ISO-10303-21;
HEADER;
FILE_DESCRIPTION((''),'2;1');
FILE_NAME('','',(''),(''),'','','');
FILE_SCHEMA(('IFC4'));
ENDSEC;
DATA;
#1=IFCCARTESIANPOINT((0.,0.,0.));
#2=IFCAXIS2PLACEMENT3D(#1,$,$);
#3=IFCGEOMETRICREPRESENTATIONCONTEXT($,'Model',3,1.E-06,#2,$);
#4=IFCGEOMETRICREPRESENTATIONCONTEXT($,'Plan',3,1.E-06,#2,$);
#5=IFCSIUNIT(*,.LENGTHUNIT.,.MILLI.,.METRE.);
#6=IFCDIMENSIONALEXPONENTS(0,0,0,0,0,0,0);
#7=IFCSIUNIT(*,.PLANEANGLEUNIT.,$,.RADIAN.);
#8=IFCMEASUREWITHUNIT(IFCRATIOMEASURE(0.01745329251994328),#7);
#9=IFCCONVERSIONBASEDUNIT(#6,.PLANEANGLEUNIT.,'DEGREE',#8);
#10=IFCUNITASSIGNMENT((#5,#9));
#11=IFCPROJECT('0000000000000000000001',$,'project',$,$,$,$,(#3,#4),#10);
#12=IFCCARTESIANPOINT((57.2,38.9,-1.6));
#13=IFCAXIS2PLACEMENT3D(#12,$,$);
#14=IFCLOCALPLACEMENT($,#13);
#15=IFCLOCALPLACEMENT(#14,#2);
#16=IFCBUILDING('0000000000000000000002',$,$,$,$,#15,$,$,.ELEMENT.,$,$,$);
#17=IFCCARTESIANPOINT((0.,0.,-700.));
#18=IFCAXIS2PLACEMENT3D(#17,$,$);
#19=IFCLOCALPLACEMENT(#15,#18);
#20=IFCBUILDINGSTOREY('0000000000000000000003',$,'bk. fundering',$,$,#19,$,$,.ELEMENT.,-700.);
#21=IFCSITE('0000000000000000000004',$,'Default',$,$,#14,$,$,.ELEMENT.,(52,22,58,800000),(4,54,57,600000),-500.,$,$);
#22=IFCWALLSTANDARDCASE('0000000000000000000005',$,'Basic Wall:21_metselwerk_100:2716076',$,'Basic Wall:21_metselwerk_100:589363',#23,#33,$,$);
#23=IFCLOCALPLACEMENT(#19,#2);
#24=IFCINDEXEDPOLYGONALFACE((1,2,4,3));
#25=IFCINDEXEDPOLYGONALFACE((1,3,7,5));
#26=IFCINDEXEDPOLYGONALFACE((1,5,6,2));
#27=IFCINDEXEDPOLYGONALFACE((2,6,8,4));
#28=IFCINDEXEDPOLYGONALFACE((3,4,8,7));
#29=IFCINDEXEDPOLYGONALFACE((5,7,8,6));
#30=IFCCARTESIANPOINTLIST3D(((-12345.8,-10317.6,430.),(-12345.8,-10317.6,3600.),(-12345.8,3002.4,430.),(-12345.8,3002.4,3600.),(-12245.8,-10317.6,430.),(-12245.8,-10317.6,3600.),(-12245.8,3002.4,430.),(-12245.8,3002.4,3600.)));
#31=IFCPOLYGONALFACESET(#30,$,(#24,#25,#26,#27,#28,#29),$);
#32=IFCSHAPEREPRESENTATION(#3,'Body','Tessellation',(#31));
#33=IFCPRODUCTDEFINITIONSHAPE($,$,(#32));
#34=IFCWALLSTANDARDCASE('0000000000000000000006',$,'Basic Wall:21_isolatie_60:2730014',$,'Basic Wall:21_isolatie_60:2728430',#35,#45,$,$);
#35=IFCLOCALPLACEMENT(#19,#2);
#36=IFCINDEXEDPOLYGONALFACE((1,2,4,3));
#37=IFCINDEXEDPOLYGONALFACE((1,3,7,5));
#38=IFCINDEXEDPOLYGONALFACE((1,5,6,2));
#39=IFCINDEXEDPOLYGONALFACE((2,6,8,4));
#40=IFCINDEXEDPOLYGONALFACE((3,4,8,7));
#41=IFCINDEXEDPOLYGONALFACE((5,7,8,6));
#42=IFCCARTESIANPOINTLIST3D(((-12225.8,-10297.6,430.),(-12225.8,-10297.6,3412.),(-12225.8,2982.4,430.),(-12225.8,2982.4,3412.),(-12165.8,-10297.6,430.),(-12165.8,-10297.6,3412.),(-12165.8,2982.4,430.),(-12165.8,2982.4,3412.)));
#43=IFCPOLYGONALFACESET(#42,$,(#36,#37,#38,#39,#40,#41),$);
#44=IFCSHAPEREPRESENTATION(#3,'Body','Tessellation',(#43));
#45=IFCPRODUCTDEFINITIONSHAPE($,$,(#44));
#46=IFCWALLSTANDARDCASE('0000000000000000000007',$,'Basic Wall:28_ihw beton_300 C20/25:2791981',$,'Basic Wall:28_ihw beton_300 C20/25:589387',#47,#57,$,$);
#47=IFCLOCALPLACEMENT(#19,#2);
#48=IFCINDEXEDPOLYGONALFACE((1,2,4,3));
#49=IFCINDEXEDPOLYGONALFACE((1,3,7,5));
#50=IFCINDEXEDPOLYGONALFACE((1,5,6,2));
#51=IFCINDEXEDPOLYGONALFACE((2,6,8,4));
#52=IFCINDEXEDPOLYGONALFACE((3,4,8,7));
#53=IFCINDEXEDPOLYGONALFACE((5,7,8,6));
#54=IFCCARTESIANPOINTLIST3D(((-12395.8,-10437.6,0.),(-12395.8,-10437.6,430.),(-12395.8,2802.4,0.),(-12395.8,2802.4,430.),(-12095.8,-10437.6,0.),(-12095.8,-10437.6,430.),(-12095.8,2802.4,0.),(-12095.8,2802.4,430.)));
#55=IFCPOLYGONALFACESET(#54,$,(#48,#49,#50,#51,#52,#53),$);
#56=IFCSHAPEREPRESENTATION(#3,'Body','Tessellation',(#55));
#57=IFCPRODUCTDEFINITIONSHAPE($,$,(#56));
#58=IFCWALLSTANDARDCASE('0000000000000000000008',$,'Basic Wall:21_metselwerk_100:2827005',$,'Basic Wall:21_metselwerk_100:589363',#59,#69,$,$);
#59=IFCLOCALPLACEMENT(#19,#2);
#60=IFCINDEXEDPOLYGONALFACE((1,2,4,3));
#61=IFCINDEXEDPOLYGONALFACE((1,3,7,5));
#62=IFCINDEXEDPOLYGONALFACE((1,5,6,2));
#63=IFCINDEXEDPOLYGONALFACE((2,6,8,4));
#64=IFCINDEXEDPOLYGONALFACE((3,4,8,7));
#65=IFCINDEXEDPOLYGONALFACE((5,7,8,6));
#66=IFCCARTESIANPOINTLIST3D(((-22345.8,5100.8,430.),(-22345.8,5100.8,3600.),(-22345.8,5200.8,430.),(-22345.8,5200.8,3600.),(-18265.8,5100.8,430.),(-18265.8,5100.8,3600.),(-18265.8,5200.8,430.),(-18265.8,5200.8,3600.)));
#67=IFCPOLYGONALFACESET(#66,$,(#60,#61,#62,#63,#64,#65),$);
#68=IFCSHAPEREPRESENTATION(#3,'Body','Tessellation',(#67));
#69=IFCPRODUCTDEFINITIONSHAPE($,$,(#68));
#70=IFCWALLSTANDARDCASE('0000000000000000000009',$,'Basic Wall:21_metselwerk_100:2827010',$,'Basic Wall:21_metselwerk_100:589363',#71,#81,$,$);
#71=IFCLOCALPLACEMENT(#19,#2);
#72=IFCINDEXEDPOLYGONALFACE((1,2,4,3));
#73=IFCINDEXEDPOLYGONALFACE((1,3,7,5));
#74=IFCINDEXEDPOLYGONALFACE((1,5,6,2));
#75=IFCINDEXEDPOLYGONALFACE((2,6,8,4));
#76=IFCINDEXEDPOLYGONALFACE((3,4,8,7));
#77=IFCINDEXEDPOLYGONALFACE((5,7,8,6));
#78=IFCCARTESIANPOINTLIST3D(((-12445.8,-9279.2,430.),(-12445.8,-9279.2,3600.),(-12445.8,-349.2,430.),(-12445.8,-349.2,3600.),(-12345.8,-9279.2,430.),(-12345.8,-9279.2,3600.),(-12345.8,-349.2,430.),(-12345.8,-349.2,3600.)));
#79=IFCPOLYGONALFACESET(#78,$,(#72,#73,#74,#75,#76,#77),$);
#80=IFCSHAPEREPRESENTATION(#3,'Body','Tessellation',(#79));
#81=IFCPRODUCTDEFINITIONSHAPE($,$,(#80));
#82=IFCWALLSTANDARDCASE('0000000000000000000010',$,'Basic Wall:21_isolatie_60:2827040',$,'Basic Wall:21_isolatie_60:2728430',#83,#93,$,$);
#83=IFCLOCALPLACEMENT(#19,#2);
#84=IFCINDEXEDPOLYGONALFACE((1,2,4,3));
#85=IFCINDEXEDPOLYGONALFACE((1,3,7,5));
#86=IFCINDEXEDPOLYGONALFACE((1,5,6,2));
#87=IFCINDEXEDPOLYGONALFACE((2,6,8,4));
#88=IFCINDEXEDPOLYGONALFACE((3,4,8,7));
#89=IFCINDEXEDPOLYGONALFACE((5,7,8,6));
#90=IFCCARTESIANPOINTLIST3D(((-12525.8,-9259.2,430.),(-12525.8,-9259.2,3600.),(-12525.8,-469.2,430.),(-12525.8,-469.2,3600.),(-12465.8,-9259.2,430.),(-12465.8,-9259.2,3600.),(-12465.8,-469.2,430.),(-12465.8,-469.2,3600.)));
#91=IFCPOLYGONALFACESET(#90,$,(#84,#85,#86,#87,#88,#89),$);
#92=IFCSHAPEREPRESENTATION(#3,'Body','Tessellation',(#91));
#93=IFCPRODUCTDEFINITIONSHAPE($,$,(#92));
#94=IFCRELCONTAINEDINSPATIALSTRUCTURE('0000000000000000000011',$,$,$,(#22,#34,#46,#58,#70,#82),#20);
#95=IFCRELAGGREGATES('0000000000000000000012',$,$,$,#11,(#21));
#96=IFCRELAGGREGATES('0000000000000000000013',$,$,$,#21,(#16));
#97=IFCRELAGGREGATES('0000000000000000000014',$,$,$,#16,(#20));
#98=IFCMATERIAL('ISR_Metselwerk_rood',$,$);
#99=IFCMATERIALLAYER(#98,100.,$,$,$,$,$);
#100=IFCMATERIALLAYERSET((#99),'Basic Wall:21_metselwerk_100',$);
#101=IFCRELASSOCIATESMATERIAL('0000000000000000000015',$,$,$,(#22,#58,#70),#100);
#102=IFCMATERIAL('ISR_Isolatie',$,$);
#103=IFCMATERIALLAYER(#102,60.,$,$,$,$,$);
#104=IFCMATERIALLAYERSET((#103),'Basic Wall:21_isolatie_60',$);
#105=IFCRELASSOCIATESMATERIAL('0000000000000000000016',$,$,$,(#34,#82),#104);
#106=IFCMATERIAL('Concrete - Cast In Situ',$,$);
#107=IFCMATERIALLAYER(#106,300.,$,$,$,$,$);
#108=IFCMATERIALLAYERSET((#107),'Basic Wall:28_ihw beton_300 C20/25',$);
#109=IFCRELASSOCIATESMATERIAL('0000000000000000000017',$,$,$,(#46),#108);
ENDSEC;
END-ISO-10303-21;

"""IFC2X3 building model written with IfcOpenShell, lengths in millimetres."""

from ifc_helpers import new_model, entity, si_unit, converted_unit, frame, frame_2d, origin, place, context, project, spatial, rectangle, extrude, material, layer, layer_set, layer_usage, element, save


model = new_model("IFC2X3")

# Units and contexts
model_context = context("Model", 3, precision=1e-06, world=origin())
plan_context = context("Plan", 3, precision=1e-06, world=origin())
ifc_project = project(units=[si_unit("LENGTHUNIT", "METRE", prefix="MILLI"), converted_unit("PLANEANGLEUNIT", "DEGREE", entity("IfcRatioMeasure", 0.01745329251994328), si_unit("PLANEANGLEUNIT", "RADIAN"), dimensions=[0, 0, 0, 0, 0, 0, 0])], contexts=[model_context, plan_context])

# Site, building, storey
site_placement = place(None, frame((57.2, 38.9, -1.6)))
site = spatial("IfcSite", under=ifc_project, at=site_placement, Name="Default", CompositionType="ELEMENT", RefLatitude=(52, 22, 58, 800000), RefLongitude=(4, 54, 57, 600000), RefElevation=-500.0)
building_placement = place(site_placement, origin())
building = spatial("IfcBuilding", under=site, at=building_placement, CompositionType="ELEMENT")
storey_placement = place(building_placement, frame((0.0, 0.0, -700.0)))
storey = spatial("IfcBuildingStorey", under=building, at=storey_placement, Name="bk. fundering", CompositionType="ELEMENT", Elevation=-700.0)

# Shared definitions
ifc_material_1 = material(Name="ISR_Metselwerk_rood")
ifc_layer_1 = layer(ifc_material_1, 100.0)
ifc_layer_set_1 = layer_set([ifc_layer_1], Name="Basic Wall:21_metselwerk_100")

# Walls
ifc_layer_usage_1 = layer_usage(ifc_layer_set_1, "AXIS2", "POSITIVE", -50.0)
wall_1_placement = place(storey_placement, frame((-12295.8, 3052.4, 430.0), z_axis=(0.0, 0.0, 1.0), x_axis=(0.0, -1.0, 0.0)))
element("IfcWallStandardCase", 1, at=wall_1_placement, inside=storey, material=ifc_layer_usage_1, Name="Basic Wall:21_metselwerk_100:2716076", ObjectType="Basic Wall:21_metselwerk_100:589363", context=model_context, shape_type="SweptSolid", body=[
    extrude(rectangle(XDim=13320.0, YDim=100.0, at=frame_2d((6710.0, 0.0), x_axis=(-1.0, 0.0))), origin(), (0.0, 0.0, 1.0), 3170.0),
])
ifc_material_2 = material(Name="ISR_Isolatie")
ifc_layer_2 = layer(ifc_material_2, 60.0)
ifc_layer_set_2 = layer_set([ifc_layer_2], Name="Basic Wall:21_isolatie_60")
ifc_layer_usage_2 = layer_usage(ifc_layer_set_2, "AXIS2", "NEGATIVE", 30.0)
wall_2_placement = place(storey_placement, frame((-12195.8, 2982.4, 430.0), z_axis=(0.0, 0.0, 1.0), x_axis=(0.0, -1.0, 0.0)))
element("IfcWallStandardCase", 2, at=wall_2_placement, inside=storey, material=ifc_layer_usage_2, Name="Basic Wall:21_isolatie_60:2730014", ObjectType="Basic Wall:21_isolatie_60:2728430", context=model_context, shape_type="SweptSolid", body=[
    extrude(rectangle(XDim=13280.0, YDim=60.0, at=frame_2d((6640.0, 0.0), x_axis=(-1.0, 0.0))), origin(), (0.0, 0.0, 1.0), 2982.0),
])

# Wall
ifc_material_3 = material(Name="Concrete - Cast In Situ")
ifc_layer_3 = layer(ifc_material_3, 300.0)
ifc_layer_set_3 = layer_set([ifc_layer_3], Name="Basic Wall:28_ihw beton_300 C20/25")
ifc_layer_usage_3 = layer_usage(ifc_layer_set_3, "AXIS2", "NEGATIVE", 150.0)
wall_3_placement = place(storey_placement, frame((-12245.8, 2802.4, 0.0), z_axis=(0.0, 0.0, 1.0), x_axis=(0.0, -1.0, 0.0)))
element("IfcWallStandardCase", 3, at=wall_3_placement, inside=storey, material=ifc_layer_usage_3, Name="Basic Wall:28_ihw beton_300 C20/25:2791981", ObjectType="Basic Wall:28_ihw beton_300 C20/25:589387", context=model_context, shape_type="SweptSolid", body=[
    extrude(rectangle(XDim=13240.0, YDim=300.0, at=frame_2d((6620.0, 0.0), x_axis=(-1.0, 0.0))), origin(), (0.0, 0.0, 1.0), 430.0),
])

# Wall
ifc_layer_usage_4 = layer_usage(ifc_layer_set_1, "AXIS2", "POSITIVE", -50.0)
wall_4_placement = place(storey_placement, frame((-22345.8, 5150.8, 430.0)))
element("IfcWallStandardCase", 4, at=wall_4_placement, inside=storey, material=ifc_layer_usage_4, Name="Basic Wall:21_metselwerk_100:2827005", ObjectType="Basic Wall:21_metselwerk_100:589363", context=model_context, shape_type="SweptSolid", body=[
    extrude(rectangle(XDim=4080.0, YDim=100.0, at=frame_2d((2040.0, 0.0), x_axis=(-1.0, 0.0))), origin(), (0.0, 0.0, 1.0), 3170.0),
])

# Walls
ifc_layer_usage_5 = layer_usage(ifc_layer_set_1, "AXIS2", "NEGATIVE", 50.0)
wall_5_placement = place(storey_placement, frame((-12395.8, -349.2, 430.0), z_axis=(0.0, 0.0, 1.0), x_axis=(0.0, -1.0, 0.0)))
element("IfcWallStandardCase", 5, at=wall_5_placement, inside=storey, material=ifc_layer_usage_5, Name="Basic Wall:21_metselwerk_100:2827010", ObjectType="Basic Wall:21_metselwerk_100:589363", context=model_context, shape_type="SweptSolid", body=[
    extrude(rectangle(XDim=8930.0, YDim=100.0, at=frame_2d((4465.0, 0.0), x_axis=(-1.0, 0.0))), origin(), (0.0, 0.0, 1.0), 3170.0),
])
ifc_layer_usage_6 = layer_usage(ifc_layer_set_2, "AXIS2", "POSITIVE", -30.0)
wall_6_placement = place(storey_placement, frame((-12495.8, -469.2, 430.0), z_axis=(0.0, 0.0, 1.0), x_axis=(0.0, -1.0, 0.0)))
element("IfcWallStandardCase", 6, at=wall_6_placement, inside=storey, material=ifc_layer_usage_6, Name="Basic Wall:21_isolatie_60:2827040", ObjectType="Basic Wall:21_isolatie_60:2728430", context=model_context, shape_type="SweptSolid", body=[
    extrude(rectangle(XDim=8790.0, YDim=60.0, at=frame_2d((4395.0, 0.0), x_axis=(-1.0, 0.0))), origin(), (0.0, 0.0, 1.0), 3170.0),
])

save(model, "model.ifc")
